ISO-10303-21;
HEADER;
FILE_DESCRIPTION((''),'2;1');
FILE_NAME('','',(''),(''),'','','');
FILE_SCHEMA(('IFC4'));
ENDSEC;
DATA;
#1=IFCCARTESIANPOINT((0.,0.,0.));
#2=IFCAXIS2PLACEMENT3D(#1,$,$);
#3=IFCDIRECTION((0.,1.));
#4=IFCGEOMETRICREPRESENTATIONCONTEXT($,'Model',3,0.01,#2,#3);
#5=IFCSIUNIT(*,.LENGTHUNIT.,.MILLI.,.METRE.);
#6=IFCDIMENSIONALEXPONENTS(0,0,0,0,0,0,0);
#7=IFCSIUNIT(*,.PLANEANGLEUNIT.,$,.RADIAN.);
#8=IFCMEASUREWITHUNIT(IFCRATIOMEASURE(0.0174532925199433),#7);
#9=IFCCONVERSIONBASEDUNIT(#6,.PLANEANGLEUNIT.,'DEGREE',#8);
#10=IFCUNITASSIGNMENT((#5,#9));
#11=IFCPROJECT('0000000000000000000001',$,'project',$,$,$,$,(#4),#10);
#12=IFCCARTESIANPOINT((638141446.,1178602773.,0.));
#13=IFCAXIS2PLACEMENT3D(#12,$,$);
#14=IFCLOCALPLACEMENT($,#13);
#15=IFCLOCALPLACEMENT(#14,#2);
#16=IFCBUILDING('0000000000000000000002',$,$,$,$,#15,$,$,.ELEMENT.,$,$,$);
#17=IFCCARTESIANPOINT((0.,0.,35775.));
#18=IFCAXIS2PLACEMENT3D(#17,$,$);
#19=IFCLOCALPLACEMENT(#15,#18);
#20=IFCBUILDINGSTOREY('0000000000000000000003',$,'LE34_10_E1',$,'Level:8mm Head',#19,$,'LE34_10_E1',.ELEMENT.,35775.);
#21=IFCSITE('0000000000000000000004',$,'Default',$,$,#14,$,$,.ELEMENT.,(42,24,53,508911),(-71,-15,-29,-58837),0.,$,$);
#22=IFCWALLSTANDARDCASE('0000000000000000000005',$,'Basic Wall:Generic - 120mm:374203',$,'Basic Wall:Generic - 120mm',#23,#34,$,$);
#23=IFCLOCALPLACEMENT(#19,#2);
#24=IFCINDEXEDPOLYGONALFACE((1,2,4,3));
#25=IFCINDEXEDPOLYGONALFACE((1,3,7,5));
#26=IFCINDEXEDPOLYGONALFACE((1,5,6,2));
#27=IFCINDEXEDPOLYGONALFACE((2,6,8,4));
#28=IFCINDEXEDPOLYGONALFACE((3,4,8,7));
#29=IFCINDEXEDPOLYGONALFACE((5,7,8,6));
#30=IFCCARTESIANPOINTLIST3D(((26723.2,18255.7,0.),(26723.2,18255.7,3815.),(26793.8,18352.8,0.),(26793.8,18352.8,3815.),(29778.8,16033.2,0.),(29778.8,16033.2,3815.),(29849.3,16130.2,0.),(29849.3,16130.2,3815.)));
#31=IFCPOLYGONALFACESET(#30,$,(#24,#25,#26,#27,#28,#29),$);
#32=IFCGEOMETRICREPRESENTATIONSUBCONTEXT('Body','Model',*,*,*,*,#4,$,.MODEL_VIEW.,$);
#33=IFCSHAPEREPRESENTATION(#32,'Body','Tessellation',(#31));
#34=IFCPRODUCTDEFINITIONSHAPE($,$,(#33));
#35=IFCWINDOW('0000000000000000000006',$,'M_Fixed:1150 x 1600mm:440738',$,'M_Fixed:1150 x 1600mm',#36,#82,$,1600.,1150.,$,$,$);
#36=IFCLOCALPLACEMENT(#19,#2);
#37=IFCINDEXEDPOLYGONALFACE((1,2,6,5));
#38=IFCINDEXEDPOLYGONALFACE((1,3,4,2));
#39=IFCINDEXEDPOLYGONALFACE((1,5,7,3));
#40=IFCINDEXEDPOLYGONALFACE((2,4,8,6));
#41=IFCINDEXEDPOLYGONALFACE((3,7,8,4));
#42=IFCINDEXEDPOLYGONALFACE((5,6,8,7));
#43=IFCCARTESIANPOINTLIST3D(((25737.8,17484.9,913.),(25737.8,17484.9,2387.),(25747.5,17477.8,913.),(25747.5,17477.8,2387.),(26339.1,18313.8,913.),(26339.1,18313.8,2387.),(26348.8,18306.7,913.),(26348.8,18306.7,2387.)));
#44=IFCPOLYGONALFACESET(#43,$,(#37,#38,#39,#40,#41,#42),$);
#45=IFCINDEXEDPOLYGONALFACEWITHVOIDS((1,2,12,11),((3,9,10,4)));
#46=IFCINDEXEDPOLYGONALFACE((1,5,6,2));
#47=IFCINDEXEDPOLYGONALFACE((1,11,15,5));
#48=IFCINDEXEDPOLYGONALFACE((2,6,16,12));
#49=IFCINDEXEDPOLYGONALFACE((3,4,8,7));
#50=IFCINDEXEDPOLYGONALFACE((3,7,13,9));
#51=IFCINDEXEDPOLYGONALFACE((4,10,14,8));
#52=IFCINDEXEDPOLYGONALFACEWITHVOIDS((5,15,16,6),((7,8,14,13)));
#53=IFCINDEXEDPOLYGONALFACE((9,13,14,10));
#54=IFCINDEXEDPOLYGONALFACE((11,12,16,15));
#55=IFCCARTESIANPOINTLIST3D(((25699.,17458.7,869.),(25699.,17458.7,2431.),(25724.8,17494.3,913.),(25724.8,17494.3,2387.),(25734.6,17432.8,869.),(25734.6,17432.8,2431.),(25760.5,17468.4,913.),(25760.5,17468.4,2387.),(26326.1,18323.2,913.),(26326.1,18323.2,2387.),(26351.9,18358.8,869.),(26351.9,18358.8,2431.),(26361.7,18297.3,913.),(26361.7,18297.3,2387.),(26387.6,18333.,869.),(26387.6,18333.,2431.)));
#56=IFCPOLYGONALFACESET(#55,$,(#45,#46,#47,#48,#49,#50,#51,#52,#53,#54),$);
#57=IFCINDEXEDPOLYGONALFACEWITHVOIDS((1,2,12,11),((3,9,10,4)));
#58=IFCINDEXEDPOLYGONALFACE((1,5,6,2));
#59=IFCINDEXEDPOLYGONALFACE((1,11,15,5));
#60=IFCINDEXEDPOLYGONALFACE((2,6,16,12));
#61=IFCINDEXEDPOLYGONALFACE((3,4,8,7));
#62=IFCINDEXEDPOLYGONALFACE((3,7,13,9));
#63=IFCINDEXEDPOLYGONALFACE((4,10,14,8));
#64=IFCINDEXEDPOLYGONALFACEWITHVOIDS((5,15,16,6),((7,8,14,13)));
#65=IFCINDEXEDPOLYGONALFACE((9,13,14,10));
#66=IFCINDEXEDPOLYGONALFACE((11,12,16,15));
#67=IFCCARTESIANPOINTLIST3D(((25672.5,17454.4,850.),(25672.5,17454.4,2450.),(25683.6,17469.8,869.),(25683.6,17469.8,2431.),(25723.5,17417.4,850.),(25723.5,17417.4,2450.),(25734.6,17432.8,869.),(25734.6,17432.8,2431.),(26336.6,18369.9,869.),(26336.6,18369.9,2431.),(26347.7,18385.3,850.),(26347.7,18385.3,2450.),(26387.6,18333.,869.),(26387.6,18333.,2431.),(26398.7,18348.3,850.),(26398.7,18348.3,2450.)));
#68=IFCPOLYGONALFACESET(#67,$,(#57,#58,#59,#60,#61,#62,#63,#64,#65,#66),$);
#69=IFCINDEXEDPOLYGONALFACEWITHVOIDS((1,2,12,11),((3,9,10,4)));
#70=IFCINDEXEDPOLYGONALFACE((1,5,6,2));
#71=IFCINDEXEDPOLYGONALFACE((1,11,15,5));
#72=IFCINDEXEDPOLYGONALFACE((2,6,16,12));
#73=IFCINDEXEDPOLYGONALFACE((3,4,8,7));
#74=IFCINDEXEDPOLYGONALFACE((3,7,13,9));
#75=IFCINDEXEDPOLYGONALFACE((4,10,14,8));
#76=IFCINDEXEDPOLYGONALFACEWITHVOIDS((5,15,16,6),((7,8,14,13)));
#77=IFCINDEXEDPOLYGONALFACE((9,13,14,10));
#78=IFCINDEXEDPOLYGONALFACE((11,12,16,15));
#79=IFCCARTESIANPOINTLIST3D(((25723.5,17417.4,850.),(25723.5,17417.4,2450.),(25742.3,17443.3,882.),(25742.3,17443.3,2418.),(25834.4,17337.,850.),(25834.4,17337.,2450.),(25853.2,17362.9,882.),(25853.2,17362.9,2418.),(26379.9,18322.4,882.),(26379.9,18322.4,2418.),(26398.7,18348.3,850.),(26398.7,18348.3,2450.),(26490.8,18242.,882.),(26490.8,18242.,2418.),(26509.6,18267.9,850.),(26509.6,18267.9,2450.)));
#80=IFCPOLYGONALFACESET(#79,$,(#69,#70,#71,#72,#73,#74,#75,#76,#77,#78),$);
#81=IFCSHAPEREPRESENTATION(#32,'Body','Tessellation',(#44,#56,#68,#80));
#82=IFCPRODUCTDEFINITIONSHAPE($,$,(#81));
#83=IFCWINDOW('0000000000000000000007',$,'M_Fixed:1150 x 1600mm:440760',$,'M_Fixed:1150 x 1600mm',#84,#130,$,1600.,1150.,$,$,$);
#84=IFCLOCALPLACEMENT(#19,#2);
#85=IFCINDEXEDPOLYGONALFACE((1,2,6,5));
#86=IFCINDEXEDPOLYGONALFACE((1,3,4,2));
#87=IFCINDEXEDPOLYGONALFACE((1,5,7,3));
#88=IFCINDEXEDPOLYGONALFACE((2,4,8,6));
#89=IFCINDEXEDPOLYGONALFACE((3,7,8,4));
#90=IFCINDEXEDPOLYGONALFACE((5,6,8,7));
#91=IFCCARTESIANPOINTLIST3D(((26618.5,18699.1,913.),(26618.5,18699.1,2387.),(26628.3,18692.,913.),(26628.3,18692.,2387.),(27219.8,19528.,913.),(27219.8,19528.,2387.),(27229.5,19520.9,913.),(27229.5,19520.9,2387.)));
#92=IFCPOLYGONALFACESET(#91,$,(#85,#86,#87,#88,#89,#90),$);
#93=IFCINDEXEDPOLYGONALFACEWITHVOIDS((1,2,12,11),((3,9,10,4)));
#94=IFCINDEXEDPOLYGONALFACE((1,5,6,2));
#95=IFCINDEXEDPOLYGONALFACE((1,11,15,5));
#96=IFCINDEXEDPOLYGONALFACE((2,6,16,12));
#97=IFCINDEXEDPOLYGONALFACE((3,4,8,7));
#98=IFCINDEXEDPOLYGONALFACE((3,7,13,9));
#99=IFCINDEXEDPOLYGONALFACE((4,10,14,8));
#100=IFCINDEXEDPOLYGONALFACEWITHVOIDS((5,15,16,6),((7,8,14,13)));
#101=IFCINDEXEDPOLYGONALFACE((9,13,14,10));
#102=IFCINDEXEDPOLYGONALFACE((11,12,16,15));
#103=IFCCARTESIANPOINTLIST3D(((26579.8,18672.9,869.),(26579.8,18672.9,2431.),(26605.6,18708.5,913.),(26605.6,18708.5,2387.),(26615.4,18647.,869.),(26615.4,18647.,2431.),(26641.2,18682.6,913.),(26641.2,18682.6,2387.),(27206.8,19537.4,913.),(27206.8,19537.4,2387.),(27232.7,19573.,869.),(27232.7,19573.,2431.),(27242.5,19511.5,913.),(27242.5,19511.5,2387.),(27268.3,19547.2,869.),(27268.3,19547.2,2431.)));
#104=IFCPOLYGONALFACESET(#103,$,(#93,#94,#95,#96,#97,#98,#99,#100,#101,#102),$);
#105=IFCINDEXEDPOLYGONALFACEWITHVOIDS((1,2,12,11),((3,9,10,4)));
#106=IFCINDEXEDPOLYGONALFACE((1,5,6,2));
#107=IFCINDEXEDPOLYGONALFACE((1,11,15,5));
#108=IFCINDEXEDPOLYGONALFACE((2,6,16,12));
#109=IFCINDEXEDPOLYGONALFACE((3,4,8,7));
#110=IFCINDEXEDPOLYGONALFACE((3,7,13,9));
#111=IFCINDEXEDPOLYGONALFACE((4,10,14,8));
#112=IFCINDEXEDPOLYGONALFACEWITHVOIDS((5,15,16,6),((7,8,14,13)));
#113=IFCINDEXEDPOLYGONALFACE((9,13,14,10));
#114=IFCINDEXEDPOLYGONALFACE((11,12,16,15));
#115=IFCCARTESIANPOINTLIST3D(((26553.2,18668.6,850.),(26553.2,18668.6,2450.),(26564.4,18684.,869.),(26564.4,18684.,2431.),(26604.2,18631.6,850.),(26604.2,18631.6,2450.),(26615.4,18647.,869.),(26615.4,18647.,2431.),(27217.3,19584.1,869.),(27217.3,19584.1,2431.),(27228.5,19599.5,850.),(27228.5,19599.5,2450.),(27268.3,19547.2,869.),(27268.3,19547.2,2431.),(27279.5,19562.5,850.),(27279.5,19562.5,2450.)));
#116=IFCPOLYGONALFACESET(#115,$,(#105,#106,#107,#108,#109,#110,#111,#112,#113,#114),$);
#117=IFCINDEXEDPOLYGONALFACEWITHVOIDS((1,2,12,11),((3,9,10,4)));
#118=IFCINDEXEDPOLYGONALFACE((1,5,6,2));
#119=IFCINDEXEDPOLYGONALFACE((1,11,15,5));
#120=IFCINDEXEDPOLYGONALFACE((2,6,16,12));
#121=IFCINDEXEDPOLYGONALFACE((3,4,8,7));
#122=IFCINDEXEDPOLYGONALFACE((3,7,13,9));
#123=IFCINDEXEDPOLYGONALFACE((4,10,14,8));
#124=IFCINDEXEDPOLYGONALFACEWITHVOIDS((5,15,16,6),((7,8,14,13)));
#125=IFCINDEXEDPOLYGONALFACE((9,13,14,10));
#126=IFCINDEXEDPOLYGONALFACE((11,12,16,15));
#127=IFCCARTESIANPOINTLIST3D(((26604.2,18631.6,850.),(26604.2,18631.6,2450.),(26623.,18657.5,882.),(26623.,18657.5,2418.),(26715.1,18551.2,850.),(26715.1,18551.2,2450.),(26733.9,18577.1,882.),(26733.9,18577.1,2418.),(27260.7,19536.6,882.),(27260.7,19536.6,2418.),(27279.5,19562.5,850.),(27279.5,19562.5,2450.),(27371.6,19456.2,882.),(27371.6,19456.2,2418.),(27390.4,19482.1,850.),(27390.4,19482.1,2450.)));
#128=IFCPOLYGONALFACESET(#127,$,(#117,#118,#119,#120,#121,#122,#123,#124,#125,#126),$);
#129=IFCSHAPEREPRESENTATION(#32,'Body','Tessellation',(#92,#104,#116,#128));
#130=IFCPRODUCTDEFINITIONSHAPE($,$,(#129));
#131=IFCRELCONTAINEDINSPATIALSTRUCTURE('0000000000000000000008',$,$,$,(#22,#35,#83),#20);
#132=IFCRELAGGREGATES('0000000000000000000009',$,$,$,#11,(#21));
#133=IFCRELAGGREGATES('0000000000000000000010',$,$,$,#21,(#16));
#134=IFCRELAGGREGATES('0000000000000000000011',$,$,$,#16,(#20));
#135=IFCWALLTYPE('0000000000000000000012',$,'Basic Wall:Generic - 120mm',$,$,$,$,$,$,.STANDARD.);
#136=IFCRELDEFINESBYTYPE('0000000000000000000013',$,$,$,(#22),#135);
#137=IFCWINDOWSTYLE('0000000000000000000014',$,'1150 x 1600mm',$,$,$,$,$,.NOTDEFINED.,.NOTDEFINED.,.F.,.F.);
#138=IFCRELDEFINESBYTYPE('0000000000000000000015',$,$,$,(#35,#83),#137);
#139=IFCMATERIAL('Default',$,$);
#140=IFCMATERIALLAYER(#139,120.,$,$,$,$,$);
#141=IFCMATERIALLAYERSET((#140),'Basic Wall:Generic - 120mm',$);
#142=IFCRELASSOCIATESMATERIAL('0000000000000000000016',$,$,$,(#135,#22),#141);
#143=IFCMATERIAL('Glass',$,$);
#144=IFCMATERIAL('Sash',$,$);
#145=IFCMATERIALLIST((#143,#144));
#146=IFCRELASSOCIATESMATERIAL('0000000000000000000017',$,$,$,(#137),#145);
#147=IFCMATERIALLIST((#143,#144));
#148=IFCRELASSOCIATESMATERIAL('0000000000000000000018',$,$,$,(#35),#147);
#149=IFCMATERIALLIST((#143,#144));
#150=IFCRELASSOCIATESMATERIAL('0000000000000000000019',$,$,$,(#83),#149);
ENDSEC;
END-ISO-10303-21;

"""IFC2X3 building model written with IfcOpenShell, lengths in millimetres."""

from ifc_helpers import new_model, entity, si_unit, converted_unit, direction, frame, frame_2d, origin, place, context, subcontext, project, spatial, polyline, rectangle, outline, extrude, source, transform, mapped, material, material_list, layer, layer_set, layer_usage, type_object, type_shapes, element, save


model = new_model("IFC2X3")

# Units and contexts
model_context = context("Model", 3, precision=0.01, world=origin(), true_north=direction((0.0, 1.0)))
body_context = subcontext(model_context, "Body", "Model", "MODEL_VIEW")
ifc_project = project(units=[si_unit("LENGTHUNIT", "METRE", prefix="MILLI"), converted_unit("PLANEANGLEUNIT", "DEGREE", entity("IfcRatioMeasure", 0.0174532925199433), si_unit("PLANEANGLEUNIT", "RADIAN"), dimensions=[0, 0, 0, 0, 0, 0, 0])], contexts=[model_context])

# Site, building, storey
site_placement = place(None, frame((638141446.0, 1178602773.0, 0.0)))
site = spatial("IfcSite", under=ifc_project, at=site_placement, Name="Default", CompositionType="ELEMENT", RefLatitude=(42, 24, 53, 508911), RefLongitude=(-71, -15, -29, -58837), RefElevation=0.0)
building_placement = place(site_placement, origin())
building = spatial("IfcBuilding", under=site, at=building_placement, CompositionType="ELEMENT")
storey_placement = place(building_placement, frame((0.0, 0.0, 35775.0)))
storey = spatial("IfcBuildingStorey", under=building, at=storey_placement, Name="LE34_10_E1", ObjectType="Level:8mm Head", LongName="LE34_10_E1", CompositionType="ELEMENT", Elevation=35775.0)

# Wall
ifc_material_1 = material(Name="Default")
ifc_layer_1 = layer(ifc_material_1, 120.0)
ifc_layer_set_1 = layer_set([ifc_layer_1], Name="Basic Wall:Generic - 120mm")
ifc_layer_usage_1 = layer_usage(ifc_layer_set_1, "AXIS2", "NEGATIVE", 60.0)
wall_type_1 = type_object("IfcWallType", Name="Basic Wall:Generic - 120mm", PredefinedType="STANDARD", material=ifc_layer_set_1)
wall_1_placement = place(storey_placement, frame((26758.5, 18304.3, 0.0), z_axis=(0.0, 0.0, 1.0), x_axis=(0.808693, -0.588231, 0.0)))
element("IfcWallStandardCase", 1, at=wall_1_placement, inside=storey, type_object=wall_type_1, material=ifc_layer_usage_1, Name="Basic Wall:Generic - 120mm:374203", ObjectType="Basic Wall:Generic - 120mm", context=body_context, shape_type="SweptSolid", body=[
    extrude(rectangle(XDim=3778.4, YDim=120.0, at=frame_2d((1889.2, 0.0), x_axis=(-1.0, 0.0))), origin(), (0.0, 0.0, 1.0), 3815.0),
])

# Windows
ifc_material_2 = material(Name="Glass")
ifc_material_3 = material(Name="Sash")
ifc_material_list_1 = material_list([ifc_material_2, ifc_material_3])
ifc_material_list_2 = material_list([ifc_material_2, ifc_material_3])
window_style = type_object("IfcWindowStyle", Name="1150 x 1600mm", ConstructionType="NOTDEFINED", OperationType="NOTDEFINED", ParameterTakesPrecedence=False, Sizeable=False, material=ifc_material_list_2)
shared_shape = source(origin(), body_context, "Body", "SweptSolid", [
    extrude(rectangle(XDim=12.0, YDim=1024.0, at=frame_2d((0.0, 0.0), x_axis=(1.0, 0.0))), frame((575.0, 269.0, 63.0), z_axis=(0.0, 0.0, 1.0), x_axis=(0.0, -1.0, 0.0)), (0.0, 0.0, 1.0), 1474.0),
    extrude(outline(polyline([(-556.0, -781.0), (556.0, -781.0), (556.0, 781.0), (-556.0, 781.0), (-556.0, -781.0)]), holes=[polyline([(-512.0, -737.0), (-512.0, 737.0), (512.0, 737.0), (512.0, -737.0), (-512.0, -737.0)])]), frame((575.0, 247.0, 800.0), z_axis=(0.0, 1.0, 0.0), x_axis=(1.0, 0.0, 0.0)), (0.0, 0.0, 1.0), 44.0),
    extrude(outline(polyline([(-575.0, -800.0), (575.0, -800.0), (575.0, 800.0), (-575.0, 800.0), (-575.0, -800.0)]), holes=[polyline([(-556.0, -781.0), (-556.0, 781.0), (556.0, 781.0), (556.0, -781.0), (-556.0, -781.0)])]), frame((575.0, 247.0, 800.0), z_axis=(0.0, 1.0, 0.0), x_axis=(1.0, 0.0, 0.0)), (0.0, 0.0, 1.0), 63.0),
    extrude(outline(polyline([(-575.0, -800.0), (575.0, -800.0), (575.0, 800.0), (-575.0, 800.0), (-575.0, -800.0)]), holes=[polyline([(-543.0, -768.0), (-543.0, 768.0), (543.0, 768.0), (543.0, -768.0), (-543.0, -768.0)])]), frame((575.0, 110.0, 800.0), z_axis=(0.0, 1.0, 0.0), x_axis=(1.0, 0.0, 0.0)), (0.0, 0.0, 1.0), 137.0),
])
type_shapes(window_style, [shared_shape])
window_1_placement = place(storey_placement, frame((25923.4, 17272.4, 850.0), z_axis=(0.0, 0.0, 1.0), x_axis=(0.587164, 0.809468, 0.0)))
element("IfcWindow", 2, at=window_1_placement, inside=storey, type_object=window_style, material=ifc_material_list_1, Name="M_Fixed:1150 x 1600mm:440738", ObjectType="M_Fixed:1150 x 1600mm", OverallHeight=1600.0, OverallWidth=1150.0, context=body_context, shape_type="MappedRepresentation", body=[
    mapped(shared_shape, transform((0.0, 0.0, 0.0), scale=1.0)),
])
ifc_material_list_3 = material_list([ifc_material_2, ifc_material_3])
window_2_placement = place(storey_placement, frame((26804.2, 18486.6, 850.0), z_axis=(0.0, 0.0, 1.0), x_axis=(0.587164, 0.809468, 0.0)))
element("IfcWindow", 3, at=window_2_placement, inside=storey, type_object=window_style, material=ifc_material_list_3, Name="M_Fixed:1150 x 1600mm:440760", ObjectType="M_Fixed:1150 x 1600mm", OverallHeight=1600.0, OverallWidth=1150.0, context=body_context, shape_type="MappedRepresentation", body=[
    mapped(shared_shape, transform((0.0, 0.0, 0.0), scale=1.0)),
])

save(model, "model.ifc")
